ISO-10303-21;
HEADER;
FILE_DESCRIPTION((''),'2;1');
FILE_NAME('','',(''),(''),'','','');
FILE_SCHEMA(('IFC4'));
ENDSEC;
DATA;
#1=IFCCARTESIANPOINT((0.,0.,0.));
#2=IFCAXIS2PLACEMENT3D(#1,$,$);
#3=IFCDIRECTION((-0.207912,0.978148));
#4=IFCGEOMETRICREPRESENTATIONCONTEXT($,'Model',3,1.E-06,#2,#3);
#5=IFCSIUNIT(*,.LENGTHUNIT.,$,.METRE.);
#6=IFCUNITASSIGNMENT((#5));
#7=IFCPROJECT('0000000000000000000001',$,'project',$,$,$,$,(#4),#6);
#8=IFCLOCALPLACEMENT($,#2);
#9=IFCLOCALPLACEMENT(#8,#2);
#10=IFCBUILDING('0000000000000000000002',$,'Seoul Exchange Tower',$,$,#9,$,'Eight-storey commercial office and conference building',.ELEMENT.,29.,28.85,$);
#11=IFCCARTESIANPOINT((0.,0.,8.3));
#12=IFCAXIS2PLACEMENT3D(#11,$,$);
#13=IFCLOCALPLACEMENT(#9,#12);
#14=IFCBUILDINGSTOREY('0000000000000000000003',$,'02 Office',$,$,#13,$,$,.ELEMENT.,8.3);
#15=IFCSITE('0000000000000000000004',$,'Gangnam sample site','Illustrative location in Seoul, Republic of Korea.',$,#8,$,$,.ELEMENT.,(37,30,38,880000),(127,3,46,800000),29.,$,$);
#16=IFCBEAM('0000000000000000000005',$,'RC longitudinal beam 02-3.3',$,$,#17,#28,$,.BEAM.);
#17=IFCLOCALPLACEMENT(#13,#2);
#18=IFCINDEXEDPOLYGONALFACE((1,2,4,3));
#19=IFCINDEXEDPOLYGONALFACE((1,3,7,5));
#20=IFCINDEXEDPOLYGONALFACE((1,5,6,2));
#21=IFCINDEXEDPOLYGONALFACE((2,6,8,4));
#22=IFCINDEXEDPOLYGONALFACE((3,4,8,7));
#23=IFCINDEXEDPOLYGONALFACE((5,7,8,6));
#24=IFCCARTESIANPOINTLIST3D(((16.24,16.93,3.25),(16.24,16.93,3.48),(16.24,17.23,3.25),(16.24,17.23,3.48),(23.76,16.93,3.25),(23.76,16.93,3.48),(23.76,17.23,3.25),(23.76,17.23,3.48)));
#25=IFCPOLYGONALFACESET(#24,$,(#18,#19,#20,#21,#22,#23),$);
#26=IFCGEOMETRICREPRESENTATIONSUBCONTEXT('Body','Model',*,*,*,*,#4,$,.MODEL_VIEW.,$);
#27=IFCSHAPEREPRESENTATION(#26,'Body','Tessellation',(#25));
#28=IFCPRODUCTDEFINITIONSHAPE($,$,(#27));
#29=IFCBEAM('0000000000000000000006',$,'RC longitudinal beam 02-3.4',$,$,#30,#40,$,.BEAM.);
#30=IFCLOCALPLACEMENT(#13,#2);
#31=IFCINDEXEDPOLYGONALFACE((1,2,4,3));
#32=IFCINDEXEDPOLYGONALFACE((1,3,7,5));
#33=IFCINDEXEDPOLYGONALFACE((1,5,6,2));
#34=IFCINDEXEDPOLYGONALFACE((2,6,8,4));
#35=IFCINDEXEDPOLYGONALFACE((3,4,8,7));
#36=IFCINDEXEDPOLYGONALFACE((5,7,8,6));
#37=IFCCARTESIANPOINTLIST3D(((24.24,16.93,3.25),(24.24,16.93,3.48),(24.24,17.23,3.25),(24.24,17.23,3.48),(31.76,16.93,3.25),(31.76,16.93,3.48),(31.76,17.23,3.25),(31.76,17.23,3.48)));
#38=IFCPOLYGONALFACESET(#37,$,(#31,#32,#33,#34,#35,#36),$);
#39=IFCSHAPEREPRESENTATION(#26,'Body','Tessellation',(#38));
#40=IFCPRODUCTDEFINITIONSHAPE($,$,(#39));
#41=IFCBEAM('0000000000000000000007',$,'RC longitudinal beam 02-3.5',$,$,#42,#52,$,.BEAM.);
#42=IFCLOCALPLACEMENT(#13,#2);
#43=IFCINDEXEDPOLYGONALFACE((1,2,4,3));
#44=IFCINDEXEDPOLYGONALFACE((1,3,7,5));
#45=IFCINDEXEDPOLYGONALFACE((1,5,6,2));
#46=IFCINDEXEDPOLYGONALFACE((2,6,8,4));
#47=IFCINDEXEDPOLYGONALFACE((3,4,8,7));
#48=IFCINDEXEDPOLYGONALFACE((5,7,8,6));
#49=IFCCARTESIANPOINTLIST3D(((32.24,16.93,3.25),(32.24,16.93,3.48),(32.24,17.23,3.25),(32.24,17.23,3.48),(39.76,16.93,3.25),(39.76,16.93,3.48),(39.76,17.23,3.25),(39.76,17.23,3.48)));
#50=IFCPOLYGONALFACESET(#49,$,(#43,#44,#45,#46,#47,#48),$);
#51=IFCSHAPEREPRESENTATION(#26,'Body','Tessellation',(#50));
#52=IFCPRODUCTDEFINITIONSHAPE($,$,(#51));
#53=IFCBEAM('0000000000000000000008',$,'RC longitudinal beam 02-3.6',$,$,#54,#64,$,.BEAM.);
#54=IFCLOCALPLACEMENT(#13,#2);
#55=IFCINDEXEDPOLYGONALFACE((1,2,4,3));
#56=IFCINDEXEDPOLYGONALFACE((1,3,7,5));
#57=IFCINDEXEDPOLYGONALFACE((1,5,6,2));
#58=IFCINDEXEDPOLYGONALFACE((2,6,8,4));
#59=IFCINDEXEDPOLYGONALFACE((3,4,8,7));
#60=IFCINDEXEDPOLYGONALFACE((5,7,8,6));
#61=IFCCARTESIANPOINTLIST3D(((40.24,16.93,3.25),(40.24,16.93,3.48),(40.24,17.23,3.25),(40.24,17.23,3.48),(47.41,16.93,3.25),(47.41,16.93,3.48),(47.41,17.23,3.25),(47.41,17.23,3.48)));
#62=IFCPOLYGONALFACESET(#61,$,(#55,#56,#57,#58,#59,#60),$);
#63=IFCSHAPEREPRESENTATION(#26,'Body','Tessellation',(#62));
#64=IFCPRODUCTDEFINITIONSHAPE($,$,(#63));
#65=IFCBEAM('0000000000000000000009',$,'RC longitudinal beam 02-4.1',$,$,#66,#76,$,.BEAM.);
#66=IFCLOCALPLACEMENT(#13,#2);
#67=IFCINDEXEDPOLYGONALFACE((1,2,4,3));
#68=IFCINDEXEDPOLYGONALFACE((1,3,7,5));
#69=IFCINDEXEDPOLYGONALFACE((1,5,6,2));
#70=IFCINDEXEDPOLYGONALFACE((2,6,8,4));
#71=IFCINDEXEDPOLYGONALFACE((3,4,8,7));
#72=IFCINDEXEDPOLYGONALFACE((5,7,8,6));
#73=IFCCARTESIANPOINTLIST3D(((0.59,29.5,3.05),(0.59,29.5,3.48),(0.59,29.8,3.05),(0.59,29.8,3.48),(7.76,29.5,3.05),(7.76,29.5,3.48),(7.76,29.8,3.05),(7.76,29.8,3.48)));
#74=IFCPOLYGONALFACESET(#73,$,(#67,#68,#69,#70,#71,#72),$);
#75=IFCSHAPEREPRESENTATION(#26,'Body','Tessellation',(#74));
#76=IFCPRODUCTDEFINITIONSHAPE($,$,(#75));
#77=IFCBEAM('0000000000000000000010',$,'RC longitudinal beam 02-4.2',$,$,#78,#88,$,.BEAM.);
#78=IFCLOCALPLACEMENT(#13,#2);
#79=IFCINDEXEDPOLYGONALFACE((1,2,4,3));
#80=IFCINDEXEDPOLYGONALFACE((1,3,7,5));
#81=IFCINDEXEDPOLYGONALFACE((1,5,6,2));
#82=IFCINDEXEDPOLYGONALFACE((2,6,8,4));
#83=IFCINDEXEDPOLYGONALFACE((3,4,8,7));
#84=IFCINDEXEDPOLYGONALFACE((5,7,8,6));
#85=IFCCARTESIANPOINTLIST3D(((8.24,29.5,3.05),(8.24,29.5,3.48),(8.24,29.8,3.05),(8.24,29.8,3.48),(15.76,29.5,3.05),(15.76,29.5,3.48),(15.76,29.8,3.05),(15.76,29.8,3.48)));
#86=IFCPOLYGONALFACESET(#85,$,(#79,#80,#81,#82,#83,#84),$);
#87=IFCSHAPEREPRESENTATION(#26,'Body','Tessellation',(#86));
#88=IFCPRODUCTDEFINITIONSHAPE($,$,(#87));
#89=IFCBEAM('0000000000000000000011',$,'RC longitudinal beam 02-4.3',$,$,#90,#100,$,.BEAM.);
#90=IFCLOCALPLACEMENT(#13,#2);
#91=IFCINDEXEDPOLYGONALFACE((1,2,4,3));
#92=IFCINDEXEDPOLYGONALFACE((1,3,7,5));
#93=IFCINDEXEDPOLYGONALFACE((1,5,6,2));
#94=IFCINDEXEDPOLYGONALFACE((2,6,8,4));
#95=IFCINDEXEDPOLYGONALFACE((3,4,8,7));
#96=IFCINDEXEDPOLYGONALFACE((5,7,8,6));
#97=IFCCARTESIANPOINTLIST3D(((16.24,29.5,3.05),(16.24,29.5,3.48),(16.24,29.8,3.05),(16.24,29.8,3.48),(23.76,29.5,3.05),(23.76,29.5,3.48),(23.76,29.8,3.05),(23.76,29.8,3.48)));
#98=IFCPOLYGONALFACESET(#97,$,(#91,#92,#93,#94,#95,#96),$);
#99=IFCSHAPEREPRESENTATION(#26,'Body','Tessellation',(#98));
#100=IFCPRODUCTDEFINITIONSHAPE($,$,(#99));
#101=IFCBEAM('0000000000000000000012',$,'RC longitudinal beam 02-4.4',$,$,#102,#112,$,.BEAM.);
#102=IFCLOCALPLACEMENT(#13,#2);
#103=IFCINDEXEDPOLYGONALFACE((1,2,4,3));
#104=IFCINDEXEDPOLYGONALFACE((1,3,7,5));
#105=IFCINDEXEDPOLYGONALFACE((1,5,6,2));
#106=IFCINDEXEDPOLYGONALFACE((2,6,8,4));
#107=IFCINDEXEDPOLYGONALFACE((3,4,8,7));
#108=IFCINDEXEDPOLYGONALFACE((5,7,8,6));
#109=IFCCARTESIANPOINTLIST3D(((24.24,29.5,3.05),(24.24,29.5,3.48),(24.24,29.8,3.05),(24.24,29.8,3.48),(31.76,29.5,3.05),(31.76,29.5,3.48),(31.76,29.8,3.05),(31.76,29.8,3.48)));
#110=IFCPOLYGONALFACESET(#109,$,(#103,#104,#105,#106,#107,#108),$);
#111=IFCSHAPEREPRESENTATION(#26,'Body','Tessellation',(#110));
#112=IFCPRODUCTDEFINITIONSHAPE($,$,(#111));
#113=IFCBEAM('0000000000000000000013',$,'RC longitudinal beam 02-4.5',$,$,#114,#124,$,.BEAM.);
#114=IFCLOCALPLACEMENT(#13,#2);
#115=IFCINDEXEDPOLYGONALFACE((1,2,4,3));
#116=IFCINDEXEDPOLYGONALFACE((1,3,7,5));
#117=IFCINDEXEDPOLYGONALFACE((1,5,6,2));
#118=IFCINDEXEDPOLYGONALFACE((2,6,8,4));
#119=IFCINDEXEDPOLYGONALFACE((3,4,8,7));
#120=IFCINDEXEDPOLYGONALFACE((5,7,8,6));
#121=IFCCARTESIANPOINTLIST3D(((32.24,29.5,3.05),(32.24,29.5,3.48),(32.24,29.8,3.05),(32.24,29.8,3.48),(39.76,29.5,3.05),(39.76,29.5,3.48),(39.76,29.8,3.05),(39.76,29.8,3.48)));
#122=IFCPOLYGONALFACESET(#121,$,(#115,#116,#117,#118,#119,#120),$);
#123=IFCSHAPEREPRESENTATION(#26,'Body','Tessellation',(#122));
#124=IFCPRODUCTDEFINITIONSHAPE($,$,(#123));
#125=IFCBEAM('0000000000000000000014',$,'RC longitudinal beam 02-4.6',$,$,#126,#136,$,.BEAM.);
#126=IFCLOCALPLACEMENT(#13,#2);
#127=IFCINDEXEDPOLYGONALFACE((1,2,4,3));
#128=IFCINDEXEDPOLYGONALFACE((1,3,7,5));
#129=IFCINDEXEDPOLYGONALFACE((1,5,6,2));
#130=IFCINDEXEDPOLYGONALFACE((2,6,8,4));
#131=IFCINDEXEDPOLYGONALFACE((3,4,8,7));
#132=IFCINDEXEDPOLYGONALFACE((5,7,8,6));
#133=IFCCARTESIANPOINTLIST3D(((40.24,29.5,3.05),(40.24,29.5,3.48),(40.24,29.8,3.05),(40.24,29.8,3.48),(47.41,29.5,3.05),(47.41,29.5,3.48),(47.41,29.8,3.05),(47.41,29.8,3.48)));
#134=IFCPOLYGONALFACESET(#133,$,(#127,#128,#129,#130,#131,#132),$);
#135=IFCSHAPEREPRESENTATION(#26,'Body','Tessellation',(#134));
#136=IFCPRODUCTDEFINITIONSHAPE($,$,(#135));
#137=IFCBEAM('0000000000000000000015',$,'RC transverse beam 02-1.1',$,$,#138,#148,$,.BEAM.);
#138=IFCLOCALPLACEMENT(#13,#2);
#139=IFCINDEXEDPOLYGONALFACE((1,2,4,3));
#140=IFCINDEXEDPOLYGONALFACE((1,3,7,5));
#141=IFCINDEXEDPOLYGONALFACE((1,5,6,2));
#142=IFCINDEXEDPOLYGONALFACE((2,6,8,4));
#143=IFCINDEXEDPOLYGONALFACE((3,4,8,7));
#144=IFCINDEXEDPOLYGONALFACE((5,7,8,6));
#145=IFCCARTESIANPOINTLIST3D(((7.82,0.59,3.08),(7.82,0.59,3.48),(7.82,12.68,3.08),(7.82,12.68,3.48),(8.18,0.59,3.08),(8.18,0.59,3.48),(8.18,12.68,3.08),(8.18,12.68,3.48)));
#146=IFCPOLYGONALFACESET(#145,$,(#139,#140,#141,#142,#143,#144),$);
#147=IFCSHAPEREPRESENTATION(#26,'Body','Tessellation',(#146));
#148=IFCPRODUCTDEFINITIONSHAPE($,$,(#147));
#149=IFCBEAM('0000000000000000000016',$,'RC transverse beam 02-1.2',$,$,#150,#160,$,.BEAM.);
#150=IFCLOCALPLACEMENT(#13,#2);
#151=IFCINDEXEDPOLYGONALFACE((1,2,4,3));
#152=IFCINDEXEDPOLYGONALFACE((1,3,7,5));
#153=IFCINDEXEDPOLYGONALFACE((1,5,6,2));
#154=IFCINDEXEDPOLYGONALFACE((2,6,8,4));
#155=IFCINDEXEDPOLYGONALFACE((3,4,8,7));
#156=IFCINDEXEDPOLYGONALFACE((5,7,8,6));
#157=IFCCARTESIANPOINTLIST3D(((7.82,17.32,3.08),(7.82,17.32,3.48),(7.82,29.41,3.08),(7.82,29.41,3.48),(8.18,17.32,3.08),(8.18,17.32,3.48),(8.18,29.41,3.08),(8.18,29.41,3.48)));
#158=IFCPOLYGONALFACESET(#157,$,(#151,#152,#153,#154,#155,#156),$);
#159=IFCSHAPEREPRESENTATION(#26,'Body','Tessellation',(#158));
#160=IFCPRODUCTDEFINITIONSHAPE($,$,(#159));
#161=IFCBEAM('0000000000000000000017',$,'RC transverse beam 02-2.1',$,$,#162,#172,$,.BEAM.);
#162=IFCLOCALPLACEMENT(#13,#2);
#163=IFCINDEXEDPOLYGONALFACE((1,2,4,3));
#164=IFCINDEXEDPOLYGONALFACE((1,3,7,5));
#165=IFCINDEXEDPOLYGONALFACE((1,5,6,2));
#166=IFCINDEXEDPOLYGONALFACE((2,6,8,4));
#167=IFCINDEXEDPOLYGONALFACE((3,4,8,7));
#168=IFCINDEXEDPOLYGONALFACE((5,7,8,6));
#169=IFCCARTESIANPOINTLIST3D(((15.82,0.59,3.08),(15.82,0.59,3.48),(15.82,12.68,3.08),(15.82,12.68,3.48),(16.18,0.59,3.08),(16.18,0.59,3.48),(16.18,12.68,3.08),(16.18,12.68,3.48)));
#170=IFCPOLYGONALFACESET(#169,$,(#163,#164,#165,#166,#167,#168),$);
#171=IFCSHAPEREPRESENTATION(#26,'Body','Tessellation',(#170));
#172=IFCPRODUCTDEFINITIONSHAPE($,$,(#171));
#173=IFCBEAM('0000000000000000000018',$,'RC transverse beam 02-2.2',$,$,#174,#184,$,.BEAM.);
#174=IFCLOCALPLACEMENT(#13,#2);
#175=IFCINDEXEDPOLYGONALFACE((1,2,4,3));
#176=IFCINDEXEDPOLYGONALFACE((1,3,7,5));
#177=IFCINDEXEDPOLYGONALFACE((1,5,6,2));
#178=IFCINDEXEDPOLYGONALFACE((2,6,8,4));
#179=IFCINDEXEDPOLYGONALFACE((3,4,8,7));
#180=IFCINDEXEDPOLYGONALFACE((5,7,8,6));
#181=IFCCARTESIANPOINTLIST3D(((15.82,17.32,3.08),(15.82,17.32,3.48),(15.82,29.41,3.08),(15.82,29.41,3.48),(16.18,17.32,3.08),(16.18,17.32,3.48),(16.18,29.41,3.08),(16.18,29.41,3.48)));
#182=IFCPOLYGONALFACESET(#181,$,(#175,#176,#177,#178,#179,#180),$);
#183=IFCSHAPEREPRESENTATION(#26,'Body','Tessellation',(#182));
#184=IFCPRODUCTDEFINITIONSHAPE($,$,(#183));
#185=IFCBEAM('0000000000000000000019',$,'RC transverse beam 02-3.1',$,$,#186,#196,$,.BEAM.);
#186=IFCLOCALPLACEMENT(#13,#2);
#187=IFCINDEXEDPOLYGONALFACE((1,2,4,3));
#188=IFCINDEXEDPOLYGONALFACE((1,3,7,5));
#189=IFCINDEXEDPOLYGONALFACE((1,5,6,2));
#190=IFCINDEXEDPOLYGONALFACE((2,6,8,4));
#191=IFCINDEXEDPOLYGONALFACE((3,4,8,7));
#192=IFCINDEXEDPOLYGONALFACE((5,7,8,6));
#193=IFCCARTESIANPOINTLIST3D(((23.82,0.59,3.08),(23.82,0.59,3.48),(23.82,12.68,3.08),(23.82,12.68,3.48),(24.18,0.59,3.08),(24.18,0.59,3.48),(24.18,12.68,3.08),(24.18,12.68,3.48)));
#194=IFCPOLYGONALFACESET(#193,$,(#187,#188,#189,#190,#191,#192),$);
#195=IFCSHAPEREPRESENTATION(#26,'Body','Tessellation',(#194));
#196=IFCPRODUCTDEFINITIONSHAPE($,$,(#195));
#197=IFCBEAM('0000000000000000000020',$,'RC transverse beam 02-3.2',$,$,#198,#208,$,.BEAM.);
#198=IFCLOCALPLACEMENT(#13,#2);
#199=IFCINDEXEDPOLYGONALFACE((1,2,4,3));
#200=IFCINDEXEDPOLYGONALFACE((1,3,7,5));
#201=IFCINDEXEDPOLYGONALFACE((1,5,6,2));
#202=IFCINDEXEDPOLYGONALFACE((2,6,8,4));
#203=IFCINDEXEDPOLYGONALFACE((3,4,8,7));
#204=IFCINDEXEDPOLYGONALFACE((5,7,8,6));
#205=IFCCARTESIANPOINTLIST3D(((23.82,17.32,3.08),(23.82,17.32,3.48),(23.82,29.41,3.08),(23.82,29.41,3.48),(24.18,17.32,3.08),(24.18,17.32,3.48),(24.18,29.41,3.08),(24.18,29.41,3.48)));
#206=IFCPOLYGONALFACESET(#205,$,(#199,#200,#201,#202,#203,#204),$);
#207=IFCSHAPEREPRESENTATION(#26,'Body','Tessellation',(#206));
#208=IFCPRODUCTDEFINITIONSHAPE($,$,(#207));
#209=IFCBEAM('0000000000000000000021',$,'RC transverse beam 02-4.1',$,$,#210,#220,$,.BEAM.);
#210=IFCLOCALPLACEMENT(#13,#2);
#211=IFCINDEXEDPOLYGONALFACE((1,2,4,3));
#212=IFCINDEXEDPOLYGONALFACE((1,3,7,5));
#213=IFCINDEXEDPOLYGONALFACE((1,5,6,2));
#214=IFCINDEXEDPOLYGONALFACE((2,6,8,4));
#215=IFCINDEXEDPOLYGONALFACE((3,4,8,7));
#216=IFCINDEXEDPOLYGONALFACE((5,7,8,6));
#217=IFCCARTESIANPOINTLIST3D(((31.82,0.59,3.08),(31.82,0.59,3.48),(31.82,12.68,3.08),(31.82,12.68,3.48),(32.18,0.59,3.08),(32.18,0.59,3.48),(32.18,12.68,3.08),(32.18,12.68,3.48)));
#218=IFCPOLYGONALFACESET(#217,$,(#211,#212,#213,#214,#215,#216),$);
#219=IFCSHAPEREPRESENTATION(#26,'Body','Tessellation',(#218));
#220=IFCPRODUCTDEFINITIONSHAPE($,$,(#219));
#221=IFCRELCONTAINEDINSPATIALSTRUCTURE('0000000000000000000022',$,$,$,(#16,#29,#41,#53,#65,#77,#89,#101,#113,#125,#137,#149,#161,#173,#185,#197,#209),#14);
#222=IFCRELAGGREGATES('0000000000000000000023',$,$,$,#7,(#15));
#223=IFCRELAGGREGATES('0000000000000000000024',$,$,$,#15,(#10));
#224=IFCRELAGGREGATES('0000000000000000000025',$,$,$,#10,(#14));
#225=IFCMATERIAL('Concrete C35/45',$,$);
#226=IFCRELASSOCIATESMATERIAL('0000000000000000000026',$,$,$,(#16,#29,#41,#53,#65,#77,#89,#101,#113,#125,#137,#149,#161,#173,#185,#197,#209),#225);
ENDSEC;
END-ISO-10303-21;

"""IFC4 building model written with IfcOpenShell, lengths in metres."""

from ifc_helpers import new_model, si_unit, direction, frame, frame_2d, origin, place, context, subcontext, project, spatial, rectangle, extrude, material, element, save


model = new_model("IFC4")

# Units and contexts
model_context = context("Model", 3, precision=1e-06, world=origin(), true_north=direction((-0.207912, 0.978148)))
body_context = subcontext(model_context, "Body", "Model", "MODEL_VIEW")
ifc_project = project(units=[si_unit("LENGTHUNIT", "METRE")], contexts=[model_context])

# Site, building, storey
site_placement = place(None, origin())
site = spatial("IfcSite", under=ifc_project, at=site_placement, Name="Gangnam sample site", Description="Illustrative location in Seoul, Republic of Korea.", CompositionType="ELEMENT", RefLatitude=(37, 30, 38, 880000), RefLongitude=(127, 3, 46, 800000), RefElevation=29.0)
building_placement = place(site_placement, origin())
building = spatial("IfcBuilding", under=site, at=building_placement, Name="Seoul Exchange Tower", LongName="Eight-storey commercial office and conference building", CompositionType="ELEMENT", ElevationOfRefHeight=29.0, ElevationOfTerrain=28.85)
storey_placement = place(building_placement, frame((0.0, 0.0, 8.3)))
storey = spatial("IfcBuildingStorey", under=building, at=storey_placement, Name="02 Office", CompositionType="ELEMENT", Elevation=8.3)

# Beams
ifc_material_1 = material(Name="Concrete C35/45")
placement_1 = place(storey_placement, origin())
element("IfcBeam", 1, at=placement_1, inside=storey, material=ifc_material_1, Name="RC longitudinal beam 02-3.3", PredefinedType="BEAM", context=body_context, shape_type="SweptSolid", body=[
    extrude(rectangle(XDim=7.52, YDim=0.3, at=frame_2d((3.76, 0.15))), frame((16.24, 16.93, 3.25)), (0.0, 0.0, 1.0), 0.23),
])
element("IfcBeam", 2, at=placement_1, inside=storey, material=ifc_material_1, Name="RC longitudinal beam 02-3.4", PredefinedType="BEAM", context=body_context, shape_type="SweptSolid", body=[
    extrude(rectangle(XDim=7.52, YDim=0.3, at=frame_2d((3.76, 0.15))), frame((24.24, 16.93, 3.25)), (0.0, 0.0, 1.0), 0.23),
])
element("IfcBeam", 3, at=placement_1, inside=storey, material=ifc_material_1, Name="RC longitudinal beam 02-3.5", PredefinedType="BEAM", context=body_context, shape_type="SweptSolid", body=[
    extrude(rectangle(XDim=7.52, YDim=0.3, at=frame_2d((3.76, 0.15))), frame((32.24, 16.93, 3.25)), (0.0, 0.0, 1.0), 0.23),
])
element("IfcBeam", 4, at=placement_1, inside=storey, material=ifc_material_1, Name="RC longitudinal beam 02-3.6", PredefinedType="BEAM", context=body_context, shape_type="SweptSolid", body=[
    extrude(rectangle(XDim=7.17, YDim=0.3, at=frame_2d((3.585, 0.15))), frame((40.24, 16.93, 3.25)), (0.0, 0.0, 1.0), 0.23),
])
element("IfcBeam", 5, at=placement_1, inside=storey, material=ifc_material_1, Name="RC longitudinal beam 02-4.1", PredefinedType="BEAM", context=body_context, shape_type="SweptSolid", body=[
    extrude(rectangle(XDim=7.17, YDim=0.3, at=frame_2d((3.585, 0.15))), frame((0.59, 29.5, 3.05)), (0.0, 0.0, 1.0), 0.43),
])
element("IfcBeam", 6, at=placement_1, inside=storey, material=ifc_material_1, Name="RC longitudinal beam 02-4.2", PredefinedType="BEAM", context=body_context, shape_type="SweptSolid", body=[
    extrude(rectangle(XDim=7.52, YDim=0.3, at=frame_2d((3.76, 0.15))), frame((8.24, 29.5, 3.05)), (0.0, 0.0, 1.0), 0.43),
])
element("IfcBeam", 7, at=placement_1, inside=storey, material=ifc_material_1, Name="RC longitudinal beam 02-4.3", PredefinedType="BEAM", context=body_context, shape_type="SweptSolid", body=[
    extrude(rectangle(XDim=7.52, YDim=0.3, at=frame_2d((3.76, 0.15))), frame((16.24, 29.5, 3.05)), (0.0, 0.0, 1.0), 0.43),
])
element("IfcBeam", 8, at=placement_1, inside=storey, material=ifc_material_1, Name="RC longitudinal beam 02-4.4", PredefinedType="BEAM", context=body_context, shape_type="SweptSolid", body=[
    extrude(rectangle(XDim=7.52, YDim=0.3, at=frame_2d((3.76, 0.15))), frame((24.24, 29.5, 3.05)), (0.0, 0.0, 1.0), 0.43),
])
element("IfcBeam", 9, at=placement_1, inside=storey, material=ifc_material_1, Name="RC longitudinal beam 02-4.5", PredefinedType="BEAM", context=body_context, shape_type="SweptSolid", body=[
    extrude(rectangle(XDim=7.52, YDim=0.3, at=frame_2d((3.76, 0.15))), frame((32.24, 29.5, 3.05)), (0.0, 0.0, 1.0), 0.43),
])
element("IfcBeam", 10, at=placement_1, inside=storey, material=ifc_material_1, Name="RC longitudinal beam 02-4.6", PredefinedType="BEAM", context=body_context, shape_type="SweptSolid", body=[
    extrude(rectangle(XDim=7.17, YDim=0.3, at=frame_2d((3.585, 0.15))), frame((40.24, 29.5, 3.05)), (0.0, 0.0, 1.0), 0.43),
])
element("IfcBeam", 11, at=placement_1, inside=storey, material=ifc_material_1, Name="RC transverse beam 02-1.1", PredefinedType="BEAM", context=body_context, shape_type="SweptSolid", body=[
    extrude(rectangle(XDim=0.36, YDim=12.09, at=frame_2d((0.18, 6.045))), frame((7.82, 0.59, 3.08)), (0.0, 0.0, 1.0), 0.4),
])
element("IfcBeam", 12, at=placement_1, inside=storey, material=ifc_material_1, Name="RC transverse beam 02-1.2", PredefinedType="BEAM", context=body_context, shape_type="SweptSolid", body=[
    extrude(rectangle(XDim=0.36, YDim=12.09, at=frame_2d((0.18, 6.045))), frame((7.82, 17.32, 3.08)), (0.0, 0.0, 1.0), 0.4),
])
element("IfcBeam", 13, at=placement_1, inside=storey, material=ifc_material_1, Name="RC transverse beam 02-2.1", PredefinedType="BEAM", context=body_context, shape_type="SweptSolid", body=[
    extrude(rectangle(XDim=0.36, YDim=12.09, at=frame_2d((0.18, 6.045))), frame((15.82, 0.59, 3.08)), (0.0, 0.0, 1.0), 0.4),
])
element("IfcBeam", 14, at=placement_1, inside=storey, material=ifc_material_1, Name="RC transverse beam 02-2.2", PredefinedType="BEAM", context=body_context, shape_type="SweptSolid", body=[
    extrude(rectangle(XDim=0.36, YDim=12.09, at=frame_2d((0.18, 6.045))), frame((15.82, 17.32, 3.08)), (0.0, 0.0, 1.0), 0.4),
])
element("IfcBeam", 15, at=placement_1, inside=storey, material=ifc_material_1, Name="RC transverse beam 02-3.1", PredefinedType="BEAM", context=body_context, shape_type="SweptSolid", body=[
    extrude(rectangle(XDim=0.36, YDim=12.09, at=frame_2d((0.18, 6.045))), frame((23.82, 0.59, 3.08)), (0.0, 0.0, 1.0), 0.4),
])
element("IfcBeam", 16, at=placement_1, inside=storey, material=ifc_material_1, Name="RC transverse beam 02-3.2", PredefinedType="BEAM", context=body_context, shape_type="SweptSolid", body=[
    extrude(rectangle(XDim=0.36, YDim=12.09, at=frame_2d((0.18, 6.045))), frame((23.82, 17.32, 3.08)), (0.0, 0.0, 1.0), 0.4),
])
element("IfcBeam", 17, at=placement_1, inside=storey, material=ifc_material_1, Name="RC transverse beam 02-4.1", PredefinedType="BEAM", context=body_context, shape_type="SweptSolid", body=[
    extrude(rectangle(XDim=0.36, YDim=12.09, at=frame_2d((0.18, 6.045))), frame((31.82, 0.59, 3.08)), (0.0, 0.0, 1.0), 0.4),
])

save(model, "model.ifc")
